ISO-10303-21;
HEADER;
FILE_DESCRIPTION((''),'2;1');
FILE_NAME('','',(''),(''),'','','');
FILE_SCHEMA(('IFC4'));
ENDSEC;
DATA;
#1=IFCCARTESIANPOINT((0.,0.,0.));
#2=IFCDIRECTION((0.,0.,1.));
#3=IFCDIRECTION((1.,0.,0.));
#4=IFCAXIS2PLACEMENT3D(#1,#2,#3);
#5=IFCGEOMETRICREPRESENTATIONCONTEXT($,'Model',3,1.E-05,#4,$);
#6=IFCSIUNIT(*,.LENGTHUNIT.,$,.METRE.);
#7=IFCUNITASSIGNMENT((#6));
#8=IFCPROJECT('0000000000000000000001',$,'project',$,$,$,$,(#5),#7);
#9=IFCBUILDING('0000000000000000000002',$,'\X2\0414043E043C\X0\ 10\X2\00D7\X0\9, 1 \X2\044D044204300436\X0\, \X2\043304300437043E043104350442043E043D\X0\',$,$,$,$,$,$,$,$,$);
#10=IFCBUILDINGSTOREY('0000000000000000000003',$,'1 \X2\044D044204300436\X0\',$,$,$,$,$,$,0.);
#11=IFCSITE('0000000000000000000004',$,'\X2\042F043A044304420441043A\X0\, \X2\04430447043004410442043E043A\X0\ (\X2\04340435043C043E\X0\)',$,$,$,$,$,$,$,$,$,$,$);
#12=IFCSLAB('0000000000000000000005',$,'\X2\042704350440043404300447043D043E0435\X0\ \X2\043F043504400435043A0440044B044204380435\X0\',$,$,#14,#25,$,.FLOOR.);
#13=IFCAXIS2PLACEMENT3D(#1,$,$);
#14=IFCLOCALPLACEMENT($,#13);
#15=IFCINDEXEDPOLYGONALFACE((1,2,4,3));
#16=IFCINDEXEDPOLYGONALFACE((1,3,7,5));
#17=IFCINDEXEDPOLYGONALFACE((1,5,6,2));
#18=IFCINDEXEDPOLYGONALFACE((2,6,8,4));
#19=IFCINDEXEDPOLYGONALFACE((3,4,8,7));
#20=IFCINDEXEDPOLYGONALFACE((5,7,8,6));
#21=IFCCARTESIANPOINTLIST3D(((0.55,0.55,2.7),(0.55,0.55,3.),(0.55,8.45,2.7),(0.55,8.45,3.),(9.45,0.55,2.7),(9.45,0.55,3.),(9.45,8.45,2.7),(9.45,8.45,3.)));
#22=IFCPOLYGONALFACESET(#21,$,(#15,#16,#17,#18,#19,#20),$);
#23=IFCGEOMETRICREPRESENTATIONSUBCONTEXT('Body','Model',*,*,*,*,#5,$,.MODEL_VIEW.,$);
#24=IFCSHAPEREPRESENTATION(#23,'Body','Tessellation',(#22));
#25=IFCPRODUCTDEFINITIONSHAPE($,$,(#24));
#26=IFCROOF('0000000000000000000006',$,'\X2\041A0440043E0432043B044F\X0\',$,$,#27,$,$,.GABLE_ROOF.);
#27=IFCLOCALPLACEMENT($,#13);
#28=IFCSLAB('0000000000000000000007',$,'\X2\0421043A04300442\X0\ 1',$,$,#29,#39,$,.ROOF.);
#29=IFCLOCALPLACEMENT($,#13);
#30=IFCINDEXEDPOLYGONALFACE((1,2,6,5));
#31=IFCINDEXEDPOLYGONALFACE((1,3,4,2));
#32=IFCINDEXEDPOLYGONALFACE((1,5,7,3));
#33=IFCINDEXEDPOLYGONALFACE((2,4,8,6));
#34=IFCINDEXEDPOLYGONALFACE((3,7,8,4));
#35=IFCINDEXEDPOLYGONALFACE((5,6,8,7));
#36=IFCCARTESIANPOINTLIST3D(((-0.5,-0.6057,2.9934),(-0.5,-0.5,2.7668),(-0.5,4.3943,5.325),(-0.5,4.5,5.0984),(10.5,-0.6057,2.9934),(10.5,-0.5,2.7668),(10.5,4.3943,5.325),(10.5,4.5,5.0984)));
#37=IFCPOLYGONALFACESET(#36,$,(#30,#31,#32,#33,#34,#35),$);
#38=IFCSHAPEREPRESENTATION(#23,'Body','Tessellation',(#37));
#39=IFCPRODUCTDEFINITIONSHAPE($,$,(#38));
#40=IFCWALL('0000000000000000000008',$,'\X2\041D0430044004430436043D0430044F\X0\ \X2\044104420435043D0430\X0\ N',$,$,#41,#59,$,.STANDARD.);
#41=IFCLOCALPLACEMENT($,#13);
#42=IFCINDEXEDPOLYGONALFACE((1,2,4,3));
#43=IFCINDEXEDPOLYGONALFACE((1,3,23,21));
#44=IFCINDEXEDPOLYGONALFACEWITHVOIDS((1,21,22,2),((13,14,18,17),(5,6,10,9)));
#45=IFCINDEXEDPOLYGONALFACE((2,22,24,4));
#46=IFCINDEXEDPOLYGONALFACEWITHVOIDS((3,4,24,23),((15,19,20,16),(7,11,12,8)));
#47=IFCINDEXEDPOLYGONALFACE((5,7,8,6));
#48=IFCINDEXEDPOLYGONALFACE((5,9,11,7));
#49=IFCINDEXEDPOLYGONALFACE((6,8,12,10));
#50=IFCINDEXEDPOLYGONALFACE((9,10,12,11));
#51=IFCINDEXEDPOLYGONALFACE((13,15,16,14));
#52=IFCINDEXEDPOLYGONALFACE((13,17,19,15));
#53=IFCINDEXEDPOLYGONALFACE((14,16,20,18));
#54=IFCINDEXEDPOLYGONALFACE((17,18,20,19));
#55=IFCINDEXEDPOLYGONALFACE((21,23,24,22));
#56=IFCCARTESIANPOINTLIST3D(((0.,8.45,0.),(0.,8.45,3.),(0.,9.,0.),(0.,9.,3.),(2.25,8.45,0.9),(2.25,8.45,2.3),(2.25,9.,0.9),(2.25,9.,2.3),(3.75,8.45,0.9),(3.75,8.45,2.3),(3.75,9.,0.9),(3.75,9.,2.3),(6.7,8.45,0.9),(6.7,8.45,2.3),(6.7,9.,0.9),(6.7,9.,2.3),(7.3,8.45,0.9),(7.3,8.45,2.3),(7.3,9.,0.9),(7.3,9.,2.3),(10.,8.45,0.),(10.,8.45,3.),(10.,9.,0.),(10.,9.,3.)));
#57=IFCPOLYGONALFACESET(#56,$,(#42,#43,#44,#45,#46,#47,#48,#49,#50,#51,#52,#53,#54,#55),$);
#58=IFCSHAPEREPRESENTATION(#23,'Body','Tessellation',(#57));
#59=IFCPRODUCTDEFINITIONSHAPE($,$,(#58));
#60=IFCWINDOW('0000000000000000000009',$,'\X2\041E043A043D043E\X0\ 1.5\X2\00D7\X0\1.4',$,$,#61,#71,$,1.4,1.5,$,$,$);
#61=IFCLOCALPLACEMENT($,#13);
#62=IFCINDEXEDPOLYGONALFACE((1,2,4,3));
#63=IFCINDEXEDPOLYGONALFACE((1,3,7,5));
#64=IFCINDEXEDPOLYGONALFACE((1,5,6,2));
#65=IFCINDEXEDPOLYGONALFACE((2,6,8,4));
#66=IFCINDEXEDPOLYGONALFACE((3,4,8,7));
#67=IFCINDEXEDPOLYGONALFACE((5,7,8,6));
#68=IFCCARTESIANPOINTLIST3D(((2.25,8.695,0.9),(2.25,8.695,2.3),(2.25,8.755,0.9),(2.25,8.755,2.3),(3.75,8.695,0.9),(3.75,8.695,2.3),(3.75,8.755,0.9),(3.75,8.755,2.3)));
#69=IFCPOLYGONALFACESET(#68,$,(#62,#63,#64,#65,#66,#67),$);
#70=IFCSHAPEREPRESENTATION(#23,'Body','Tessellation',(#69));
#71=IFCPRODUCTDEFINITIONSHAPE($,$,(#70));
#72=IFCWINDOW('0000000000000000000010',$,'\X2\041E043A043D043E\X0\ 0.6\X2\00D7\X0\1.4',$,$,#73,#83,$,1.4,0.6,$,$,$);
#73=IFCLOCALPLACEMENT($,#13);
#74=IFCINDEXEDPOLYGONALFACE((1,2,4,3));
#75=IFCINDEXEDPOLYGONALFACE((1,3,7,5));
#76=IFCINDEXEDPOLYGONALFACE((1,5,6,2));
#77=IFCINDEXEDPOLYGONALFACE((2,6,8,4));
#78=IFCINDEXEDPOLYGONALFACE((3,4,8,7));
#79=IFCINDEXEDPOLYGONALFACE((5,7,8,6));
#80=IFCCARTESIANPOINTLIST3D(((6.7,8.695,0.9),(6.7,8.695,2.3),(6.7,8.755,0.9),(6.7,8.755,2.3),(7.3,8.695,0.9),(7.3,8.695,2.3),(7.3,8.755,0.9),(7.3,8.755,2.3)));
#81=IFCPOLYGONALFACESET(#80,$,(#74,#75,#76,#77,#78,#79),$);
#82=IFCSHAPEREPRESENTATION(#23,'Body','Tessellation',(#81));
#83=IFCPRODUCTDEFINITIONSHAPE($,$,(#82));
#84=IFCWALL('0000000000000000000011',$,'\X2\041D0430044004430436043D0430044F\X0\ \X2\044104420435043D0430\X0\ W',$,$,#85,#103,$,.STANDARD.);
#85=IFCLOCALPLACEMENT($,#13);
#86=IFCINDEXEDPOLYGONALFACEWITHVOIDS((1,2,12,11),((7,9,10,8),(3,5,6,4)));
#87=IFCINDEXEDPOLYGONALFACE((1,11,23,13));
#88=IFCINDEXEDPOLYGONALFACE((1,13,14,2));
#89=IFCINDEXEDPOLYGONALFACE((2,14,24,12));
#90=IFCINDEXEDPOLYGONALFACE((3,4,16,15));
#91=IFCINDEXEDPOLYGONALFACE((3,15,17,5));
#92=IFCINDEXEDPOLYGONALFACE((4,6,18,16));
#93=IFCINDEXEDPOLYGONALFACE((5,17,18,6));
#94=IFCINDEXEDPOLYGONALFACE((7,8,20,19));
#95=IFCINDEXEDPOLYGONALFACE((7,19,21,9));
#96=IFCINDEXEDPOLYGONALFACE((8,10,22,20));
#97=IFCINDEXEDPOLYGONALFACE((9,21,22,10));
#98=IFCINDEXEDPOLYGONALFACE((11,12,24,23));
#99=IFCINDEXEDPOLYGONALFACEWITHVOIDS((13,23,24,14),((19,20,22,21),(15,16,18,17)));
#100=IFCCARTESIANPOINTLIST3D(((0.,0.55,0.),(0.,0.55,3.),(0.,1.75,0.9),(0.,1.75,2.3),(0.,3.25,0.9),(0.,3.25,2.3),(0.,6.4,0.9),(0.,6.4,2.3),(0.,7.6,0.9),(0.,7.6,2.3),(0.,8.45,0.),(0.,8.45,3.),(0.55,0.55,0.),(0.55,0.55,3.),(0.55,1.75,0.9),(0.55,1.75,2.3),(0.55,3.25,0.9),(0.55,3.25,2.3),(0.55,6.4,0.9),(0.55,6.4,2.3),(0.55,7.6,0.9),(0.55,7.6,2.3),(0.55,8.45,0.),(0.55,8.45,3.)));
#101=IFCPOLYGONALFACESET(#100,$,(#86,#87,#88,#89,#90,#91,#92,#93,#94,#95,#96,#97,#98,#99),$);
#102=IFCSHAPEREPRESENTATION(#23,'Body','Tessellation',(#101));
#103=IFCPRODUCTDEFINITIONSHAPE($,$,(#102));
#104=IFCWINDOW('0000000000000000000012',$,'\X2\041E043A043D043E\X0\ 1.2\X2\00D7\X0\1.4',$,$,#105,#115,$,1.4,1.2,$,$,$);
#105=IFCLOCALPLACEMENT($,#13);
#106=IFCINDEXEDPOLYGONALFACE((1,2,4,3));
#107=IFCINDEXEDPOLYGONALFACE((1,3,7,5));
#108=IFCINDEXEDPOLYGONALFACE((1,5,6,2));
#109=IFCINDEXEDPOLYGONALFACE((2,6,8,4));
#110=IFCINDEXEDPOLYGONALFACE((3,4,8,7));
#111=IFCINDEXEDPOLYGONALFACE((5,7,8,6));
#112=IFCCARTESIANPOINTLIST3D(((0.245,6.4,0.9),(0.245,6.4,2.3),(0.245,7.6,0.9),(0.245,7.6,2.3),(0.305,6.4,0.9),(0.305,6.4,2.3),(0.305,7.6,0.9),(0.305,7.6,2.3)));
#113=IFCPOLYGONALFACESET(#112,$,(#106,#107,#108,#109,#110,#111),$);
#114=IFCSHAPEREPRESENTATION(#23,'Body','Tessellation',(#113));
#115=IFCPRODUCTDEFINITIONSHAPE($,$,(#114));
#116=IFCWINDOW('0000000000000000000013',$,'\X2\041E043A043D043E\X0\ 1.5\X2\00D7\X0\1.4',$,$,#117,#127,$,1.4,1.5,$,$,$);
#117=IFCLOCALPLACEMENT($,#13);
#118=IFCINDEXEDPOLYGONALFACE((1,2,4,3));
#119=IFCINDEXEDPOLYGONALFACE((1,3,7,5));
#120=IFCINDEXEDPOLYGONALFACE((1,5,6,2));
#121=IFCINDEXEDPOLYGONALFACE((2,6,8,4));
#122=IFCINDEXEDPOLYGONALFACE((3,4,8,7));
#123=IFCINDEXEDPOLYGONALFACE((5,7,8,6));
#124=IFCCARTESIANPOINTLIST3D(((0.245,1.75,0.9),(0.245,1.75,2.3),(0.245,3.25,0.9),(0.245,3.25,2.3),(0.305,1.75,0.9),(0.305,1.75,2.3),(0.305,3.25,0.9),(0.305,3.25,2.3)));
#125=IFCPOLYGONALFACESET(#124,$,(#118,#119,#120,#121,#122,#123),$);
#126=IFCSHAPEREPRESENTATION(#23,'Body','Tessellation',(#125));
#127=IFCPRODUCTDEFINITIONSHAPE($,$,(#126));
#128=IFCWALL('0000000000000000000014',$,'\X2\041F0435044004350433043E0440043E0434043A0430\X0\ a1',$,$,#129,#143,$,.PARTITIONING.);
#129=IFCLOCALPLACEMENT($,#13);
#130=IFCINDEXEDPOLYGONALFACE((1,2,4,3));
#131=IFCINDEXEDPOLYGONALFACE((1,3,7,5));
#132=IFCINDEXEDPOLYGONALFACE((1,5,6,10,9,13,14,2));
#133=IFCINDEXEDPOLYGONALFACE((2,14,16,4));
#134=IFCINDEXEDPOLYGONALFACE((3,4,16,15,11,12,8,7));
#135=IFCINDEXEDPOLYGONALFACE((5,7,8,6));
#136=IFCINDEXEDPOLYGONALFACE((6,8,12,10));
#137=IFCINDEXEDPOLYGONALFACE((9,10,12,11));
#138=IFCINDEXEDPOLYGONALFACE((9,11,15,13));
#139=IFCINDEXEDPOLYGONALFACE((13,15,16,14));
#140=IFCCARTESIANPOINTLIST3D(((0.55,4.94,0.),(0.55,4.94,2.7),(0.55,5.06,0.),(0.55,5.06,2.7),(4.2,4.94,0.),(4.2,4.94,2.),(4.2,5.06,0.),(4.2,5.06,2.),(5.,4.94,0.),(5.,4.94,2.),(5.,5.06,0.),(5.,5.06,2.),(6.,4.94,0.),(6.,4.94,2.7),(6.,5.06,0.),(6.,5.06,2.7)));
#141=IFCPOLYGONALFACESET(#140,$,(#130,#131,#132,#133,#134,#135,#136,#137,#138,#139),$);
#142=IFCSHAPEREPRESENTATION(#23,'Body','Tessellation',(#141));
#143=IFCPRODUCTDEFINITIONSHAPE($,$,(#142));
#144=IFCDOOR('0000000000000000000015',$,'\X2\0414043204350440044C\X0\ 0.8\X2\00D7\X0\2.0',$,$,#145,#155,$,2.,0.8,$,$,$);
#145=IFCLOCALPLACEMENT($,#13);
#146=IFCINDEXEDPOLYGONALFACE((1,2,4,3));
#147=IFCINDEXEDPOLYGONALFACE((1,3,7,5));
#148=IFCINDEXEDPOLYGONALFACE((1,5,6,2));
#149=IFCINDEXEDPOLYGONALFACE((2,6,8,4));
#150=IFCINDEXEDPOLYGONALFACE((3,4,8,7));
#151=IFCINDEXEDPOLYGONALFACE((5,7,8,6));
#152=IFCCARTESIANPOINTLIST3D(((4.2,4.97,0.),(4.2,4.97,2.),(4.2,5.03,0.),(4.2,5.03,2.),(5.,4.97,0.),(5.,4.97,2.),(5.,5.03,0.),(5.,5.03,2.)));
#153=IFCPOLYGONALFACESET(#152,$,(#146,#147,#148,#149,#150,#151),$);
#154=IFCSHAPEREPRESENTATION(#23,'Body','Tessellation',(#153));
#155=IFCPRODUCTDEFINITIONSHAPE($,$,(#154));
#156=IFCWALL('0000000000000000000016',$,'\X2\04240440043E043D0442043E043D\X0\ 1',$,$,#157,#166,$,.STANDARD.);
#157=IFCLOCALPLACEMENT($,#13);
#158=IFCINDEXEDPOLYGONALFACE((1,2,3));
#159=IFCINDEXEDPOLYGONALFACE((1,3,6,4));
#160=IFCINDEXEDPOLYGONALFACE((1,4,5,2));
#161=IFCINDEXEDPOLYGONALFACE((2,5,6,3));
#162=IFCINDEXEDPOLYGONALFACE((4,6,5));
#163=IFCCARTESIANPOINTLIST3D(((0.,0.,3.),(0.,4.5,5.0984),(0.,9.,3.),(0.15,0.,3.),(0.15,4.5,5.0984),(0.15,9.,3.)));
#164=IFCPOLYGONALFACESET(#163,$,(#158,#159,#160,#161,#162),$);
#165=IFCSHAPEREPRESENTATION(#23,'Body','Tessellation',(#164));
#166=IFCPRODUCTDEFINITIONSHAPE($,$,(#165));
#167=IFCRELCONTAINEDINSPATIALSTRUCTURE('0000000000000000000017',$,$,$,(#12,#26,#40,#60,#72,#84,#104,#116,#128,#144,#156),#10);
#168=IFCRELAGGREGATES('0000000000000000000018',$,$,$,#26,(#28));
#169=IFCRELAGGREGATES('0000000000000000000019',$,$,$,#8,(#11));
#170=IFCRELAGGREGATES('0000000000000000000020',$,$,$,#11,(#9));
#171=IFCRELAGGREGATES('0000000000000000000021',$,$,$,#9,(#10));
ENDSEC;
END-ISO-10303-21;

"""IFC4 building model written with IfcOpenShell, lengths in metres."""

from ifc_helpers import new_model, si_unit, frame, origin_with_axes, place, context, subcontext, project, spatial, polyline, indexed_curve, outline, extrude, element, fill, aggregate, save


model = new_model("IFC4")

# Units and contexts
model_context = context("Model", 3, precision=1e-05, world=origin_with_axes())
body_context = subcontext(model_context, "Body", "Model", "MODEL_VIEW")
ifc_project = project(units=[si_unit("LENGTHUNIT", "METRE")], contexts=[model_context])

# Site, building, storey
site = spatial("IfcSite", under=ifc_project, Name="Якутск, участок (демо)")
building = spatial("IfcBuilding", under=site, Name="Дом 10×9, 1 этаж, газобетон")
storey = spatial("IfcBuildingStorey", under=building, Name="1 этаж", Elevation=0.0)

# Slab
slab_1_placement = place(None, frame((0.0, 0.0, 2.7), z_axis=(0.0, 0.0, 1.0), x_axis=(1.0, 0.0, 0.0)))
element("IfcSlab", 1, at=slab_1_placement, inside=storey, Name="Чердачное перекрытие", PredefinedType="FLOOR", context=body_context, shape_type="SweptSolid", body=[
    extrude(outline(indexed_curve([(0.55, 0.55), (9.45, 0.55), (9.45, 8.45), (0.55, 8.45)])), None, (0.0, 0.0, 1.0), 0.3),
])

# Roof, slab
roof = element("IfcRoof", 2, inside=storey, Name="Кровля", PredefinedType="GABLE_ROOF")
slab_2_placement = place(None, frame((-0.5, -0.5, 2.7668), z_axis=(0.0, -0.422618, 0.906308), x_axis=(1.0, 0.0, 0.0)))
slab_2 = element("IfcSlab", 3, at=slab_2_placement, Name="Скат 1", PredefinedType="ROOF", context=body_context, shape_type="SweptSolid", body=[
    extrude(outline(indexed_curve([(0.0, 0.0), (11.0, 0.0), (11.0, 5.5169), (0.0, 5.5169)])), None, (0.0, 0.0, 1.0), 0.25),
])
aggregate(roof, [slab_2])

# Wall, openings, windows
wall_1_placement = place(None, frame((0.0, 8.45, 0.0), z_axis=(0.0, 0.0, 1.0), x_axis=(1.0, 0.0, 0.0)))
wall_1 = element("IfcWall", 4, at=wall_1_placement, inside=storey, Name="Наружная стена N", PredefinedType="STANDARD", context=body_context, shape_type="SweptSolid", body=[
    extrude(outline(indexed_curve([(0.0, 0.0), (0.0, 0.55), (10.0, 0.55), (10.0, 0.0), (0.0, 0.0)], self_intersect=False)), origin_with_axes(), (0.0, 0.0, 1.0), 3.0),
])
opening_1_placement = place(wall_1_placement, frame((2.25, -0.05, 0.9), z_axis=(0.0, 0.0, 1.0), x_axis=(1.0, 0.0, 0.0)))
opening_1 = element("IfcOpeningElement", 5, at=opening_1_placement, cuts=wall_1, context=body_context, shape_type="SweptSolid", body=[
    extrude(outline(indexed_curve([(0.0, 0.0), (0.0, 0.65), (1.5, 0.65), (1.5, 0.0), (0.0, 0.0)], self_intersect=False)), origin_with_axes(), (0.0, 0.0, 1.0), 1.4),
])
opening_2_placement = place(wall_1_placement, frame((7.3, -0.05, 0.9), z_axis=(0.0, 0.0, 1.0), x_axis=(0.0, 1.0, 0.0)))
opening_2 = element("IfcOpeningElement", 6, at=opening_2_placement, cuts=wall_1, context=body_context, shape_type="SweptSolid", body=[
    extrude(outline(indexed_curve([(0.0, 0.0), (0.0, 0.6), (0.65, 0.6), (0.65, 0.0), (0.0, 0.0)], self_intersect=False)), origin_with_axes(), (0.0, 0.0, 1.0), 1.4),
])
window_1_placement = place(opening_1_placement, frame((0.0, 0.295, 0.0), z_axis=(0.0, 0.0, 1.0), x_axis=(1.0, 0.0, 0.0)))
window_1 = element("IfcWindow", 7, at=window_1_placement, inside=storey, Name="Окно 1.5×1.4", OverallHeight=1.4, OverallWidth=1.5, context=body_context, shape_type="SweptSolid", body=[
    extrude(outline(indexed_curve([(0.0, 0.0), (0.0, 0.06), (1.5, 0.06), (1.5, 0.0), (0.0, 0.0)], self_intersect=False)), origin_with_axes(), (0.0, 0.0, 1.0), 1.4),
])
fill(opening_1, window_1)
window_2_placement = place(opening_2_placement, frame((0.295, 0.6, 0.0), z_axis=(0.0, 0.0, 1.0), x_axis=(0.0, -1.0, 0.0)))
window_2 = element("IfcWindow", 8, at=window_2_placement, inside=storey, Name="Окно 0.6×1.4", OverallHeight=1.4, OverallWidth=0.6, context=body_context, shape_type="SweptSolid", body=[
    extrude(outline(indexed_curve([(0.0, 0.0), (0.0, 0.06), (0.6, 0.06), (0.6, 0.0), (0.0, 0.0)], self_intersect=False)), origin_with_axes(), (0.0, 0.0, 1.0), 1.4),
])
fill(opening_2, window_2)

# Wall, openings, windows
wall_2_placement = place(None, frame((0.55, 0.55, 0.0), z_axis=(0.0, 0.0, 1.0), x_axis=(0.0, 1.0, 0.0)))
wall_2 = element("IfcWall", 9, at=wall_2_placement, inside=storey, Name="Наружная стена W", PredefinedType="STANDARD", context=body_context, shape_type="SweptSolid", body=[
    extrude(outline(indexed_curve([(0.0, 0.0), (0.0, 0.55), (7.9, 0.55), (7.9, 0.0), (0.0, 0.0)], self_intersect=False)), origin_with_axes(), (0.0, 0.0, 1.0), 3.0),
])
opening_3_placement = place(wall_2_placement, frame((5.85, -0.05, 0.9), z_axis=(0.0, 0.0, 1.0), x_axis=(1.0, 0.0, 0.0)))
opening_3 = element("IfcOpeningElement", 10, at=opening_3_placement, cuts=wall_2, context=body_context, shape_type="SweptSolid", body=[
    extrude(outline(indexed_curve([(0.0, 0.0), (0.0, 0.65), (1.2, 0.65), (1.2, 0.0), (0.0, 0.0)], self_intersect=False)), origin_with_axes(), (0.0, 0.0, 1.0), 1.4),
])
opening_4_placement = place(wall_2_placement, frame((1.2, -0.05, 0.9), z_axis=(0.0, 0.0, 1.0), x_axis=(1.0, 0.0, 0.0)))
opening_4 = element("IfcOpeningElement", 11, at=opening_4_placement, cuts=wall_2, context=body_context, shape_type="SweptSolid", body=[
    extrude(outline(indexed_curve([(0.0, 0.0), (0.0, 0.65), (1.5, 0.65), (1.5, 0.0), (0.0, 0.0)], self_intersect=False)), origin_with_axes(), (0.0, 0.0, 1.0), 1.4),
])
window_3_placement = place(opening_3_placement, frame((0.0, 0.295, 0.0), z_axis=(0.0, 0.0, 1.0), x_axis=(1.0, 0.0, 0.0)))
window_3 = element("IfcWindow", 12, at=window_3_placement, inside=storey, Name="Окно 1.2×1.4", OverallHeight=1.4, OverallWidth=1.2, context=body_context, shape_type="SweptSolid", body=[
    extrude(outline(indexed_curve([(0.0, 0.0), (0.0, 0.06), (1.2, 0.06), (1.2, 0.0), (0.0, 0.0)], self_intersect=False)), origin_with_axes(), (0.0, 0.0, 1.0), 1.4),
])
fill(opening_3, window_3)
window_4_placement = place(opening_4_placement, frame((0.0, 0.295, 0.0), z_axis=(0.0, 0.0, 1.0), x_axis=(1.0, 0.0, 0.0)))
window_4 = element("IfcWindow", 13, at=window_4_placement, inside=storey, Name="Окно 1.5×1.4", OverallHeight=1.4, OverallWidth=1.5, context=body_context, shape_type="SweptSolid", body=[
    extrude(outline(indexed_curve([(0.0, 0.0), (0.0, 0.06), (1.5, 0.06), (1.5, 0.0), (0.0, 0.0)], self_intersect=False)), origin_with_axes(), (0.0, 0.0, 1.0), 1.4),
])
fill(opening_4, window_4)

# Wall, opening, door
wall_3_placement = place(None, frame((0.55, 4.94, 0.0), z_axis=(0.0, 0.0, 1.0), x_axis=(1.0, 0.0, 0.0)))
wall_3 = element("IfcWall", 14, at=wall_3_placement, inside=storey, Name="Перегородка a1", PredefinedType="PARTITIONING", context=body_context, shape_type="SweptSolid", body=[
    extrude(outline(indexed_curve([(0.0, 0.0), (0.0, 0.12), (5.45, 0.12), (5.45, 0.0), (0.0, 0.0)], self_intersect=False)), origin_with_axes(), (0.0, 0.0, 1.0), 2.7),
])
opening_5_placement = place(wall_3_placement, frame((3.65, -0.05, 0.0), z_axis=(0.0, 0.0, 1.0), x_axis=(1.0, 0.0, 0.0)))
opening_5 = element("IfcOpeningElement", 15, at=opening_5_placement, cuts=wall_3, context=body_context, shape_type="SweptSolid", body=[
    extrude(outline(indexed_curve([(0.0, 0.0), (0.0, 0.22), (0.8, 0.22), (0.8, 0.0), (0.0, 0.0)], self_intersect=False)), origin_with_axes(), (0.0, 0.0, 1.0), 2.0),
])
door_1_placement = place(opening_5_placement, frame((0.0, 0.08, 0.0), z_axis=(0.0, 0.0, 1.0), x_axis=(1.0, 0.0, 0.0)))
door_1 = element("IfcDoor", 16, at=door_1_placement, inside=storey, Name="Дверь 0.8×2.0", OverallHeight=2.0, OverallWidth=0.8, context=body_context, shape_type="SweptSolid", body=[
    extrude(outline(indexed_curve([(0.0, 0.0), (0.0, 0.06), (0.8, 0.06), (0.8, 0.0), (0.0, 0.0)], self_intersect=False)), origin_with_axes(), (0.0, 0.0, 1.0), 2.0),
])
fill(opening_5, door_1)

# Wall
wall_4_placement = place(None, frame((0.0, 0.0, 3.0), z_axis=(1.0, 0.0, 0.0), x_axis=(0.0, 1.0, 0.0)))
element("IfcWall", 17, at=wall_4_placement, inside=storey, Name="Фронтон 1", PredefinedType="STANDARD", context=body_context, shape_type="SweptSolid", body=[
    extrude(outline(polyline([(0.0, 0.0), (9.0, 0.0), (4.5, 2.0984), (0.0, 0.0)])), origin_with_axes(), (0.0, 0.0, 1.0), 0.15),
])

save(model, "model.ifc")
